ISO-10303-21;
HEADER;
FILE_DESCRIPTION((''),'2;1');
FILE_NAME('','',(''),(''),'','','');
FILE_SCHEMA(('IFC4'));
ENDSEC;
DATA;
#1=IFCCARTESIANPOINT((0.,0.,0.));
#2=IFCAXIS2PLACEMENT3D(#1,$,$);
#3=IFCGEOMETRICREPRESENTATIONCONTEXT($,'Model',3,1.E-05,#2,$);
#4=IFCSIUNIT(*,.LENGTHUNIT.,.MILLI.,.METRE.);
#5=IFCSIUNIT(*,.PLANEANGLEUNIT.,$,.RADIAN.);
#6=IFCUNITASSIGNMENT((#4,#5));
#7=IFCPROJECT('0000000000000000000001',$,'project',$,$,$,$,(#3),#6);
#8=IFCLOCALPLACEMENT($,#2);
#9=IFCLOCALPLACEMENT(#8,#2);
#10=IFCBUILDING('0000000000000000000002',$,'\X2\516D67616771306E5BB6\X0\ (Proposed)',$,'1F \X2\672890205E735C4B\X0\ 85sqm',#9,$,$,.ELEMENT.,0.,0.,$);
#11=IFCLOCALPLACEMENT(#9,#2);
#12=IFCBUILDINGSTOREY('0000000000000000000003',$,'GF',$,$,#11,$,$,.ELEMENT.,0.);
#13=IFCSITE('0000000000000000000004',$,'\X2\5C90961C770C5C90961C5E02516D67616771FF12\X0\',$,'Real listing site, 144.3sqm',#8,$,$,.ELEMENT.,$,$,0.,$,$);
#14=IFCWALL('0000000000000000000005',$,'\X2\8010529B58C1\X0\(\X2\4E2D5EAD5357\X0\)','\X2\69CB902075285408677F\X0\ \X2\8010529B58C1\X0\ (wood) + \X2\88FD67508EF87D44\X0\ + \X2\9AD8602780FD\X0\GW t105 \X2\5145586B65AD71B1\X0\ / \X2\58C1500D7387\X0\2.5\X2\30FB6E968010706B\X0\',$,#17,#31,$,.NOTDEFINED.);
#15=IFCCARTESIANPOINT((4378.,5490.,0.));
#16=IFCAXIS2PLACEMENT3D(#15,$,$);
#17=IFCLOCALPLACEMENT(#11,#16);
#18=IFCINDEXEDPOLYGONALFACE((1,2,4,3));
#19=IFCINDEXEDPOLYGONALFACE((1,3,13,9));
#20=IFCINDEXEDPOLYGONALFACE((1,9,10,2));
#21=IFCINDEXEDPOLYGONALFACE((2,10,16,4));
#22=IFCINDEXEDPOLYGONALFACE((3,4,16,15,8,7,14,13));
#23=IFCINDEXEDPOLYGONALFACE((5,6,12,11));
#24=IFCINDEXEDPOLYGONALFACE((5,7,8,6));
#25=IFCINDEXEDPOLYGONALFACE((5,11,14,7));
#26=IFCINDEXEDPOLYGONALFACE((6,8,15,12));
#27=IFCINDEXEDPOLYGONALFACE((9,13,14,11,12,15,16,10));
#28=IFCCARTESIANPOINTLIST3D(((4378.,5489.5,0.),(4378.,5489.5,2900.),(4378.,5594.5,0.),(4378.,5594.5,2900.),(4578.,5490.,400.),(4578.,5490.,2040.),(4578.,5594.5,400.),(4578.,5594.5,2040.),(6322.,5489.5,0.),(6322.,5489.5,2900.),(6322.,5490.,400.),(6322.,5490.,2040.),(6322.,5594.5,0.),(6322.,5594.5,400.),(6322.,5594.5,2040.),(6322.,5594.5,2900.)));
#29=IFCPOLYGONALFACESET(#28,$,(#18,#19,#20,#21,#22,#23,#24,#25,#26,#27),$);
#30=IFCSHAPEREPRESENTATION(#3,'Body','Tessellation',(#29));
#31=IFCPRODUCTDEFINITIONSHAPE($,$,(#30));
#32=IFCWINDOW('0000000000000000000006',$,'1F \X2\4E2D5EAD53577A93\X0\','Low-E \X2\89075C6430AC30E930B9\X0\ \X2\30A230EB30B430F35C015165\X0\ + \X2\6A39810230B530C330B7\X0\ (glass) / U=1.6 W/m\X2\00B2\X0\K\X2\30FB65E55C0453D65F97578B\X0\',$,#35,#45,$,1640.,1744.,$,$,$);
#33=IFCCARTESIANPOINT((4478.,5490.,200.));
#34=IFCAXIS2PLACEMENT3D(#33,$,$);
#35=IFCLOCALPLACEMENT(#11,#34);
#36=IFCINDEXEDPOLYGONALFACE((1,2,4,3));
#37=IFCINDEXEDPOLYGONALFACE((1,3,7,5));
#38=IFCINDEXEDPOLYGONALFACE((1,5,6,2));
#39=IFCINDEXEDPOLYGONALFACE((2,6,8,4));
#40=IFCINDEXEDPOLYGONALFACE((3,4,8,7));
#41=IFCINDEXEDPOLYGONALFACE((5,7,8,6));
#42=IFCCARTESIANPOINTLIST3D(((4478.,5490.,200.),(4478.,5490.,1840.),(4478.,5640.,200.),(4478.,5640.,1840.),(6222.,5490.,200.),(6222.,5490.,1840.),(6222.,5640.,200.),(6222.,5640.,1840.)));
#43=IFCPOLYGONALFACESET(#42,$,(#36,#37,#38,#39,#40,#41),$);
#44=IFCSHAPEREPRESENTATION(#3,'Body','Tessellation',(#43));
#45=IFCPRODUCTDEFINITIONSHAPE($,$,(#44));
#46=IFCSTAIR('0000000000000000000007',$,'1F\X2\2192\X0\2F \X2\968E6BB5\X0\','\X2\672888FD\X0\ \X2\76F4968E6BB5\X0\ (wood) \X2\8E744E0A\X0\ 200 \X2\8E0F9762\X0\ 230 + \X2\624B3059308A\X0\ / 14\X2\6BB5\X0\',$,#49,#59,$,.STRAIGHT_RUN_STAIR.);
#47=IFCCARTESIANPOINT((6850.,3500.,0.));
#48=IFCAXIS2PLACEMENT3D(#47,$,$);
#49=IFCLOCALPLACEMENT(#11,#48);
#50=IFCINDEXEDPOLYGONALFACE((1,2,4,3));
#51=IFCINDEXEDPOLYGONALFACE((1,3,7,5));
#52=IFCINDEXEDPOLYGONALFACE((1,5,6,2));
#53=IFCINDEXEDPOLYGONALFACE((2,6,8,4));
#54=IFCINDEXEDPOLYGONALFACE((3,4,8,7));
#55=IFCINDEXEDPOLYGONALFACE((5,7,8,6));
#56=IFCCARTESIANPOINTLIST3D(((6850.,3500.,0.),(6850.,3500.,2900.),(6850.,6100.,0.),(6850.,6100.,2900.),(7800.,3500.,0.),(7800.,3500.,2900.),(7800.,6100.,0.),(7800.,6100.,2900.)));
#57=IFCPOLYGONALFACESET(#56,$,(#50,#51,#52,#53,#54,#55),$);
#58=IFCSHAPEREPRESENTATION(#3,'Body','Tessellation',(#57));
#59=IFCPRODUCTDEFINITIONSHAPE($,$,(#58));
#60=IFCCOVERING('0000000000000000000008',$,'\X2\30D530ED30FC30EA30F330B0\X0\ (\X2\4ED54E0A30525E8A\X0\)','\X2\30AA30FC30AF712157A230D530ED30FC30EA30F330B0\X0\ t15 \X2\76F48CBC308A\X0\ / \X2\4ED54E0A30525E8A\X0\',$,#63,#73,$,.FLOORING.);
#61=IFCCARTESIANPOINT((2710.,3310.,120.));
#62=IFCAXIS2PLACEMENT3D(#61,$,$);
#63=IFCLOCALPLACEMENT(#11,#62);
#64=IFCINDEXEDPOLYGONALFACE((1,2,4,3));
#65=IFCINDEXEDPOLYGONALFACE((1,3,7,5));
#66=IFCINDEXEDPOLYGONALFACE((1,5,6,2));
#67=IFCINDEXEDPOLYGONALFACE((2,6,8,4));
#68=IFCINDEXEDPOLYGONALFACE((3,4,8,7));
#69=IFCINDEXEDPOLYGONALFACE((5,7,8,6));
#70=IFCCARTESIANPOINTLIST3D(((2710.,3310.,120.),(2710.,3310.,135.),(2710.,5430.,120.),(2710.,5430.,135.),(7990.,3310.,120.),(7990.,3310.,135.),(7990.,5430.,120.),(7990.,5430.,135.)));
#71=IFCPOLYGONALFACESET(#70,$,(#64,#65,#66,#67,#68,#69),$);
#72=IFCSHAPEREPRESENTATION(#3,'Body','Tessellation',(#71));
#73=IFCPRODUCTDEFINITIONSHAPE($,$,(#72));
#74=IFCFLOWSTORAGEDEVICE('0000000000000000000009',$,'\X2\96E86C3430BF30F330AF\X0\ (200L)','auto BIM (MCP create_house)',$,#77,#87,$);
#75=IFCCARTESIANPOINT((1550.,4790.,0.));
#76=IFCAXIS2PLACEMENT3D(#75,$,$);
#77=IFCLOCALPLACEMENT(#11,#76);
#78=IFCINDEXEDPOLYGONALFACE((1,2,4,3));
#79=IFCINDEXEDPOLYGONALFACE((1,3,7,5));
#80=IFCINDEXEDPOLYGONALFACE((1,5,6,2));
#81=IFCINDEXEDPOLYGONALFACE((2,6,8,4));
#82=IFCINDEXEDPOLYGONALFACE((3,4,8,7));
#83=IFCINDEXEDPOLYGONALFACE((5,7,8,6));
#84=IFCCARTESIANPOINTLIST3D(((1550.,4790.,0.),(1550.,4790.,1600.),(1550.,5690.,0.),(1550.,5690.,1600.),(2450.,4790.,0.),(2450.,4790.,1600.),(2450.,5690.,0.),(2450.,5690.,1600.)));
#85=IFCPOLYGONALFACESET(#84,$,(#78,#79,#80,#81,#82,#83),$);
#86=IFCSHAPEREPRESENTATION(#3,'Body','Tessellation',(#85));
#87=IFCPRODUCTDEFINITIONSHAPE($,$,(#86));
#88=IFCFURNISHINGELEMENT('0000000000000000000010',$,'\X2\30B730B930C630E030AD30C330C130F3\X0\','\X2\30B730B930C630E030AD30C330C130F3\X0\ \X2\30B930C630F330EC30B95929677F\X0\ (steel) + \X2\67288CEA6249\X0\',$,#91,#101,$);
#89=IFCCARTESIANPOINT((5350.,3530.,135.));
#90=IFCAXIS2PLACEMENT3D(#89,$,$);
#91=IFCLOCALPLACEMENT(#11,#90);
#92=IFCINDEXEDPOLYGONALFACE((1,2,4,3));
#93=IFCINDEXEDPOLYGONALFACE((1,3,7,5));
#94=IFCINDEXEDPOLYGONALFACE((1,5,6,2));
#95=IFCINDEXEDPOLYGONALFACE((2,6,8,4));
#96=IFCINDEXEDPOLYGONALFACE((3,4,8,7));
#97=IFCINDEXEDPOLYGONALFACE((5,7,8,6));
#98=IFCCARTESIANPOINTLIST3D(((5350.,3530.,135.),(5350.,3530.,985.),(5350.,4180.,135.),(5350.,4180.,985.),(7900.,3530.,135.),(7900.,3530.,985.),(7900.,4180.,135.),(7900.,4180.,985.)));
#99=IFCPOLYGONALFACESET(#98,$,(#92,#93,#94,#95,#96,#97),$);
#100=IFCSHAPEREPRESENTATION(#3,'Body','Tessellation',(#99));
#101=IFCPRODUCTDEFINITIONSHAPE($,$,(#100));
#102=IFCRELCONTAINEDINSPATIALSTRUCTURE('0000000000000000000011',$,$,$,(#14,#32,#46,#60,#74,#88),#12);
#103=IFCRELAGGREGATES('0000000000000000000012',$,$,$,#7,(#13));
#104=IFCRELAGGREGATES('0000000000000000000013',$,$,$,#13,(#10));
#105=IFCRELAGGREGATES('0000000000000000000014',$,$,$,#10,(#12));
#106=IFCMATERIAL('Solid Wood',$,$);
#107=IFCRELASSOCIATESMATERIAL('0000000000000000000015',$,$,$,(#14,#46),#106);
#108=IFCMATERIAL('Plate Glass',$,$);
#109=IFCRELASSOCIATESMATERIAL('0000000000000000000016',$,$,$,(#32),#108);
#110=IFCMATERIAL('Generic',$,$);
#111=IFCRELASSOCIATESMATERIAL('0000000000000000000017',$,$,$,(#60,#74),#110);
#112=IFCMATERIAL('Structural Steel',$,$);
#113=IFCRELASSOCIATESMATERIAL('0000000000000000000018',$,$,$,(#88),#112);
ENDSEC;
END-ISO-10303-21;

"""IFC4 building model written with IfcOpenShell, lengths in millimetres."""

from ifc_helpers import new_model, si_unit, frame, frame_2d, origin, place, context, project, spatial, rectangle, extrude, material, element, fill, save


model = new_model("IFC4")

# Units and contexts
model_context = context("Model", 3, precision=1e-05, world=origin())
ifc_project = project(units=[si_unit("LENGTHUNIT", "METRE", prefix="MILLI"), si_unit("PLANEANGLEUNIT", "RADIAN")], contexts=[model_context])

# Site, building, storey
site_placement = place(None, origin())
site = spatial("IfcSite", under=ifc_project, at=site_placement, Name="岐阜県岐阜市六条東２", ObjectType="Real listing site, 144.3sqm", CompositionType="ELEMENT", RefElevation=0.0)
building_placement = place(site_placement, origin())
building = spatial("IfcBuilding", under=site, at=building_placement, Name="六条東の家 (Proposed)", ObjectType="1F 木造平屋 85sqm", CompositionType="ELEMENT", ElevationOfRefHeight=0.0, ElevationOfTerrain=0.0)
storey_placement = place(building_placement, origin())
storey = spatial("IfcBuildingStorey", under=building, at=storey_placement, Name="GF", CompositionType="ELEMENT", Elevation=0.0)

# Shared definitions
ifc_material_1 = material(Name="Solid Wood")
ifc_material_2 = material(Name="Generic")

# Shared definitions
ifc_material_3 = material(Name="Plate Glass")

# Wall, opening, window
wall_1_placement = place(storey_placement, frame((4378.0, 5490.0, 0.0)))
wall_1 = element("IfcWall", 1, at=wall_1_placement, inside=storey, material=ifc_material_1, Name="耐力壁(中庭南)", Description="構造用合板 耐力壁 (wood) + 製材軸組 + 高性能GW t105 充填断熱 / 壁倍率2.5・準耐火", PredefinedType="NOTDEFINED", context=model_context, shape_type="SweptSolid", body=[
    extrude(rectangle(XDim=1944.0, YDim=105.0, at=frame_2d((972.0, 52.0))), frame((4378.0, 5490.0, 0.0)), (0.0, 0.0, 1.0), 2900.0),
])
opening_1_placement = place(storey_placement, frame((4478.0, 5490.0, 200.0)))
opening_1 = element("IfcOpeningElement", 2, at=opening_1_placement, cuts=wall_1, PredefinedType="NOTDEFINED", context=model_context, shape_type="SweptSolid", body=[
    extrude(rectangle(XDim=1744.0, YDim=150.0, at=frame_2d((872.0, 75.0))), frame((4478.0, 5490.0, 200.0)), (0.0, 0.0, 1.0), 1640.0),
])
window_1_placement = place(storey_placement, frame((4478.0, 5490.0, 200.0)))
window_1 = element("IfcWindow", 3, at=window_1_placement, inside=storey, material=ifc_material_3, Name="1F 中庭南窓", Description="Low-E 複層ガラス アルゴン封入 + 樹脂サッシ (glass) / U=1.6 W/m²K・日射取得型", OverallHeight=1640.0, OverallWidth=1744.0, context=model_context, shape_type="SweptSolid", body=[
    extrude(rectangle(XDim=1744.0, YDim=150.0, at=frame_2d((872.0, 75.0))), frame((4478.0, 5490.0, 200.0)), (0.0, 0.0, 1.0), 1640.0),
])
fill(opening_1, window_1)

# Stair
stair_placement = place(storey_placement, frame((6850.0, 3500.0, 0.0)))
element("IfcStair", 4, at=stair_placement, inside=storey, material=ifc_material_1, Name="1F→2F 階段", Description="木製 直階段 (wood) 蹴上 200 踏面 230 + 手すり / 14段", PredefinedType="STRAIGHT_RUN_STAIR", context=model_context, shape_type="SweptSolid", body=[
    extrude(rectangle(XDim=950.0, YDim=2600.0, at=frame_2d((475.0, 1300.0))), frame((6850.0, 3500.0, 0.0)), (0.0, 0.0, 1.0), 2900.0),
])

# Covering
covering_placement = place(storey_placement, frame((2710.0, 3310.0, 120.0)))
element("IfcCovering", 5, at=covering_placement, inside=storey, material=ifc_material_2, Name="フローリング (仕上げ床)", Description="オーク無垢フローリング t15 直貼り / 仕上げ床", PredefinedType="FLOORING", context=model_context, shape_type="SweptSolid", body=[
    extrude(rectangle(XDim=5280.0, YDim=2120.0, at=frame_2d((2640.0, 1060.0))), frame((2710.0, 3310.0, 120.0)), (0.0, 0.0, 1.0), 15.0),
])

# Flow storage device
flow_storage_device_placement = place(storey_placement, frame((1550.0, 4790.0, 0.0)))
element("IfcFlowStorageDevice", 6, at=flow_storage_device_placement, inside=storey, material=ifc_material_2, Name="雨水タンク (200L)", Description="auto BIM (MCP create_house)", context=model_context, shape_type="SweptSolid", body=[
    extrude(rectangle(XDim=900.0, YDim=900.0, at=frame_2d((450.0, 450.0))), frame((1550.0, 4790.0, 0.0)), (0.0, 0.0, 1.0), 1600.0),
])

# Furnishing element
ifc_material_4 = material(Name="Structural Steel")
furnishing_placement = place(storey_placement, frame((5350.0, 3530.0, 135.0)))
element("IfcFurnishingElement", 7, at=furnishing_placement, inside=storey, material=ifc_material_4, Name="システムキッチン", Description="システムキッチン ステンレス天板 (steel) + 木質扉", context=model_context, shape_type="SweptSolid", body=[
    extrude(rectangle(XDim=2550.0, YDim=650.0, at=frame_2d((1275.0, 325.0))), frame((5350.0, 3530.0, 135.0)), (0.0, 0.0, 1.0), 850.0),
])

save(model, "model.ifc")
